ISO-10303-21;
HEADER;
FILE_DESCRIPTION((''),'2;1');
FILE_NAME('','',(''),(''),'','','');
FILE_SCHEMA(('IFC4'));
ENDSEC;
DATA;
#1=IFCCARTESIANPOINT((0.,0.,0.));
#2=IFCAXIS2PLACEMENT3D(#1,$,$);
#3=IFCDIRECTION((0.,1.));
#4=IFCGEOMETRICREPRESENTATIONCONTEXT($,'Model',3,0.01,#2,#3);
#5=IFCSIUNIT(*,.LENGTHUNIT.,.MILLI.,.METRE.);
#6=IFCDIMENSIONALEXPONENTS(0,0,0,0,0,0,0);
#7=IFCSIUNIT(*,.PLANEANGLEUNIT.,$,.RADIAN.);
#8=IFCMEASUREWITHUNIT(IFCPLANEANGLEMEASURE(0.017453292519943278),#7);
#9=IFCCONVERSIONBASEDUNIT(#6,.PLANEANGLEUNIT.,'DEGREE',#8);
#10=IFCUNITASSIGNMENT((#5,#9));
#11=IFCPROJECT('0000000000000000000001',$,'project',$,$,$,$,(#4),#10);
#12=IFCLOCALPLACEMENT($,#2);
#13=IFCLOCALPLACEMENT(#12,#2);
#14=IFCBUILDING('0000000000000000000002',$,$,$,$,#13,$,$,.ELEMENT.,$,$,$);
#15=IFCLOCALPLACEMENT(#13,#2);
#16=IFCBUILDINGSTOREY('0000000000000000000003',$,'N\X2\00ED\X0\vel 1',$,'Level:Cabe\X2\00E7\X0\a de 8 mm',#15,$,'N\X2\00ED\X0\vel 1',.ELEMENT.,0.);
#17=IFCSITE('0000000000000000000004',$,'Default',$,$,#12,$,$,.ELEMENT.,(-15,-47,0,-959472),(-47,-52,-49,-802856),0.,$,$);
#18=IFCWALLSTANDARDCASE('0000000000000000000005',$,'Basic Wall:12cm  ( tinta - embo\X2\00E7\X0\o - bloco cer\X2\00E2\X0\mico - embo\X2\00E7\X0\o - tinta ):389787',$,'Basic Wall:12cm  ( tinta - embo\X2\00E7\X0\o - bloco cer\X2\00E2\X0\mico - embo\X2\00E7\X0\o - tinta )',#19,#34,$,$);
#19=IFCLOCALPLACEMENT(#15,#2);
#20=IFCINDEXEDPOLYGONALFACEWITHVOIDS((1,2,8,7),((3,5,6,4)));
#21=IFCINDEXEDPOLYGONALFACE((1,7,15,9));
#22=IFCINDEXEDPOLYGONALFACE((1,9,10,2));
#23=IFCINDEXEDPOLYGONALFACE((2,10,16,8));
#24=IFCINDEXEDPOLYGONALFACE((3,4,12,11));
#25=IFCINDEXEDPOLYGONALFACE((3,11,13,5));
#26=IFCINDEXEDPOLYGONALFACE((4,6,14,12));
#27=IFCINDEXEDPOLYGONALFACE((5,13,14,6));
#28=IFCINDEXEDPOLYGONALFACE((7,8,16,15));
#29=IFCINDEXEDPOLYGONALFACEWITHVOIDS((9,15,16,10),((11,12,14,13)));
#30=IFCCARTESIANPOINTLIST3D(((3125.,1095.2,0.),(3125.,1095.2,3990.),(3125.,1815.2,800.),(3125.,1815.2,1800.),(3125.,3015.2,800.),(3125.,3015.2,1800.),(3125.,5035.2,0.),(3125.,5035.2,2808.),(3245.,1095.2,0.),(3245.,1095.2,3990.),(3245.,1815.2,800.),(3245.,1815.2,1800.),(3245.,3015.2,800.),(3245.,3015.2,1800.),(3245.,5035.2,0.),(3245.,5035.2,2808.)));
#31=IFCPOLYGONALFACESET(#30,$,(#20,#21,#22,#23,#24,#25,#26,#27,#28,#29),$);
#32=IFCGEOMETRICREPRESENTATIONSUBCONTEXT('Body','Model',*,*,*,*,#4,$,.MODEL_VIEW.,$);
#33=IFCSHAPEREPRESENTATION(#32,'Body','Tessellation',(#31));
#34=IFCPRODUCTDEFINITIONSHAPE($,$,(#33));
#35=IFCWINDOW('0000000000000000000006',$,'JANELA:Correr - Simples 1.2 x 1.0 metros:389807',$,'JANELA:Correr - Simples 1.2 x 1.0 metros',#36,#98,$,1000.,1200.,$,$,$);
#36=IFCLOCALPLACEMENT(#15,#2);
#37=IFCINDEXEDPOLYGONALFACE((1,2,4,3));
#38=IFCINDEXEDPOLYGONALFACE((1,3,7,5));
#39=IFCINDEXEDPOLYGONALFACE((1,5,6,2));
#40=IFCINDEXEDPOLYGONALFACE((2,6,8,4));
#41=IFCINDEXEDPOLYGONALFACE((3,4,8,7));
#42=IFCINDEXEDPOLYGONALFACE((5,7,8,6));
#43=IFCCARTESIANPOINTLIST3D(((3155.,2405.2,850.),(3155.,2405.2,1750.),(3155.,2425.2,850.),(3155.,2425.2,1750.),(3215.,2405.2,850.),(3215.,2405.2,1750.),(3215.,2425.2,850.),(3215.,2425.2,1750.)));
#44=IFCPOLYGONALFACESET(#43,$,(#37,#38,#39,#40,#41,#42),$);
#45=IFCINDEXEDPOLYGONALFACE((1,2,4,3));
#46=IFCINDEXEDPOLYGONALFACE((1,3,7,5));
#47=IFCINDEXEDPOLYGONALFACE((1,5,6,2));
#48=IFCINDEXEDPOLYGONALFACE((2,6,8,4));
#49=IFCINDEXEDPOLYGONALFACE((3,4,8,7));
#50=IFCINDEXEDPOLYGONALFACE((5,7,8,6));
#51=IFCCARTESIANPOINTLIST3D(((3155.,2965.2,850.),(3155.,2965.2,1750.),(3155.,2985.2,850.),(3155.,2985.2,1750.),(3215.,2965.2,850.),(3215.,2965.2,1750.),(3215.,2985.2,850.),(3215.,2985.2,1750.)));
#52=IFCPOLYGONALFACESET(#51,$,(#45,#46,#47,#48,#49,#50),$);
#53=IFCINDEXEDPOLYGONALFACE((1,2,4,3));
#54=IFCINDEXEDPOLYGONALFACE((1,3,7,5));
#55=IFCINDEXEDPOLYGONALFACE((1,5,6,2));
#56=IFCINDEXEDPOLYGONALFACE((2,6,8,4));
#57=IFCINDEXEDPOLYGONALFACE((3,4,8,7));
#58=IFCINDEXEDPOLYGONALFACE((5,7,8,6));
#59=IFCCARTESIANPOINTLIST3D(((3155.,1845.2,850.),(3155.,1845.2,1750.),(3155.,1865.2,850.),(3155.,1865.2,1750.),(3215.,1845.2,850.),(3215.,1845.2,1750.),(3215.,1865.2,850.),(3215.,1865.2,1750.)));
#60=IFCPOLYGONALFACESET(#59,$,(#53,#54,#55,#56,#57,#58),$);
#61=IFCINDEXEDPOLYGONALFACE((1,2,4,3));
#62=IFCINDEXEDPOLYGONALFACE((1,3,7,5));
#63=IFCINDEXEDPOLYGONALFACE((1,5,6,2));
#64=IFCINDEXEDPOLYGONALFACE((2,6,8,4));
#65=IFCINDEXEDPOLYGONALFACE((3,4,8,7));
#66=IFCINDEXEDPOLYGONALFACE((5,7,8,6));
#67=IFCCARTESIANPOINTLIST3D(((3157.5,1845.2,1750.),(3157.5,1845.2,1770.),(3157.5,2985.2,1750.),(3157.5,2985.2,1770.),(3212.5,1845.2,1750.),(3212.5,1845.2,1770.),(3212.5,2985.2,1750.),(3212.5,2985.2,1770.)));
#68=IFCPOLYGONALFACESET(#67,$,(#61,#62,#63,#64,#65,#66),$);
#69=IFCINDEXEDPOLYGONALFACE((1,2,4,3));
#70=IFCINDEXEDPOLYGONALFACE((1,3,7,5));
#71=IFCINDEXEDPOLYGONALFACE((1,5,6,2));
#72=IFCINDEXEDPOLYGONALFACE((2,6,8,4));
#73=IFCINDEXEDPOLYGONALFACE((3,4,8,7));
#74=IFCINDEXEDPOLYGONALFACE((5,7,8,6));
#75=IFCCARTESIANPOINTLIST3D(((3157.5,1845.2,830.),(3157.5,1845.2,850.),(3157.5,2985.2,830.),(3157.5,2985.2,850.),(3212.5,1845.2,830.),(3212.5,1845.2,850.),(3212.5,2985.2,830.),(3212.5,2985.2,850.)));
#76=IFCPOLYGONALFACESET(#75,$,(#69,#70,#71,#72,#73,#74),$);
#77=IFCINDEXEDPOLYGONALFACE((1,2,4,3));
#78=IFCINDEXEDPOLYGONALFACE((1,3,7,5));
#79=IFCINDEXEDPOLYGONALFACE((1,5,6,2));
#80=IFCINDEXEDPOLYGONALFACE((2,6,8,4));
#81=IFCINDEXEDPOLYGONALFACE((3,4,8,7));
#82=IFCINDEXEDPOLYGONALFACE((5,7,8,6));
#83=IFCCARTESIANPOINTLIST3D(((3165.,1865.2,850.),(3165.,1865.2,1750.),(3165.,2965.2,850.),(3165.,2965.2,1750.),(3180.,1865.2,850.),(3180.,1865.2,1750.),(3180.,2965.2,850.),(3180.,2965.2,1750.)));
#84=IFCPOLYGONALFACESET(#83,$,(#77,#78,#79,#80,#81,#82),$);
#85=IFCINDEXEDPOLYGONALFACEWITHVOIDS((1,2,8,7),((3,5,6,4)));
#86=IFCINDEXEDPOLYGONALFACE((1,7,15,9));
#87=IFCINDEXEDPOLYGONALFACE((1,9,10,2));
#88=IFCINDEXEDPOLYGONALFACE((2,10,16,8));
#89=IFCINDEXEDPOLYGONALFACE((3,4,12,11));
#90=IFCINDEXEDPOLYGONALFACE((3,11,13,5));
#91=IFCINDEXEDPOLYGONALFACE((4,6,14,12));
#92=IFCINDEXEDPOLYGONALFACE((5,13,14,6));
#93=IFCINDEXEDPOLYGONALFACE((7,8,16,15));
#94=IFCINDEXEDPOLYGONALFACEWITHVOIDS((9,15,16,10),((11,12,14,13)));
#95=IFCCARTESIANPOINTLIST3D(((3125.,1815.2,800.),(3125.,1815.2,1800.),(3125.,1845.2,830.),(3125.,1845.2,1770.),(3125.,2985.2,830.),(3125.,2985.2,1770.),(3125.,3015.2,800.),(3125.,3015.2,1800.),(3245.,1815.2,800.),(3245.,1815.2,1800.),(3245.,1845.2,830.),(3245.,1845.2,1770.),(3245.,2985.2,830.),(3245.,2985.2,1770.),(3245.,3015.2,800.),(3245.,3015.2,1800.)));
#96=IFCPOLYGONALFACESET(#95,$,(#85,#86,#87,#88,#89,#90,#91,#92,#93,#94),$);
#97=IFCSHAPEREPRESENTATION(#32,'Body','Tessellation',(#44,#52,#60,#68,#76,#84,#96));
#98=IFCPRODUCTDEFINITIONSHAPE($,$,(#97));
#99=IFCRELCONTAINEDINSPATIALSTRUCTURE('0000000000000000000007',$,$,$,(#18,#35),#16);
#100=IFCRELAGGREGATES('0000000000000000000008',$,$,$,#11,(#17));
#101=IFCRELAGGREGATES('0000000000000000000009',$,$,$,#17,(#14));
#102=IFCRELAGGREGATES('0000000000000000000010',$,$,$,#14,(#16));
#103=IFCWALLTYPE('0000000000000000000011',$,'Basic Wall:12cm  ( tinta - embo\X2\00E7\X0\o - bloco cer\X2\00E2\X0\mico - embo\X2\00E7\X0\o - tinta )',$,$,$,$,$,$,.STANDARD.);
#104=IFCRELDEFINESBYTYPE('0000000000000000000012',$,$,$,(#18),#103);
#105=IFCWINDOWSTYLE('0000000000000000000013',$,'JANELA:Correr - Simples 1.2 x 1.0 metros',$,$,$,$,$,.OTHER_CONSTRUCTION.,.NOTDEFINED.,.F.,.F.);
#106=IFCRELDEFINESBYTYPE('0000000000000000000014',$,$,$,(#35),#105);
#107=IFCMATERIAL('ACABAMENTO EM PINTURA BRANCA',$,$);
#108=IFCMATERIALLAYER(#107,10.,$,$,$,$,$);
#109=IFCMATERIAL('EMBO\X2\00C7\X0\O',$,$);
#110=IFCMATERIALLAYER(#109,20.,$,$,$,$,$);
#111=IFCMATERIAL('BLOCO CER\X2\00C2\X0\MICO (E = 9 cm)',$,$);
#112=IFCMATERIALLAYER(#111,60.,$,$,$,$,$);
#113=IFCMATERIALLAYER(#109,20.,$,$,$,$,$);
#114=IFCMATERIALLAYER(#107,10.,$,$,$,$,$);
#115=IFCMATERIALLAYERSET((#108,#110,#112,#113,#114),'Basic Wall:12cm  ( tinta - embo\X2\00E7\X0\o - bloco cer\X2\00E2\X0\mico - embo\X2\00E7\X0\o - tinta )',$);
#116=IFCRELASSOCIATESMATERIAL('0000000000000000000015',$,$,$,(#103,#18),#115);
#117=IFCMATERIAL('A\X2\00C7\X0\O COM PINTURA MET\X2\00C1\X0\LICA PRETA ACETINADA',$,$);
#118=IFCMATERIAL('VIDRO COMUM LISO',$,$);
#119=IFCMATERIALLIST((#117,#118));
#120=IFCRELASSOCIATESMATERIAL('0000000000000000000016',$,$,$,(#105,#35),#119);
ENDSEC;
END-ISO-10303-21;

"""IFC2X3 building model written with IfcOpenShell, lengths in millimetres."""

from ifc_helpers import new_model, entity, si_unit, converted_unit, direction, frame, frame_2d, origin, origin_2d_with_axis, place, context, subcontext, project, spatial, polyline, rectangle, outline, extrude, clip, bounded_halfspace, source, transform, mapped, material, material_list, layer, layer_set, layer_usage, type_object, type_shapes, element, fill, save


model = new_model("IFC2X3")

# Units and contexts
model_context = context("Model", 3, precision=0.01, world=origin(), true_north=direction((0.0, 1.0)))
body_context = subcontext(model_context, "Body", "Model", "MODEL_VIEW")
ifc_project = project(units=[si_unit("LENGTHUNIT", "METRE", prefix="MILLI"), converted_unit("PLANEANGLEUNIT", "DEGREE", entity("IfcPlaneAngleMeasure", 0.017453292519943278), si_unit("PLANEANGLEUNIT", "RADIAN"), dimensions=[0, 0, 0, 0, 0, 0, 0])], contexts=[model_context])

# Site, building, storey
site_placement = place(None, origin())
site = spatial("IfcSite", under=ifc_project, at=site_placement, Name="Default", CompositionType="ELEMENT", RefLatitude=(-15, -47, 0, -959472), RefLongitude=(-47, -52, -49, -802856), RefElevation=0.0)
building_placement = place(site_placement, origin())
building = spatial("IfcBuilding", under=site, at=building_placement, CompositionType="ELEMENT")
storey_placement = place(building_placement, origin())
storey = spatial("IfcBuildingStorey", under=building, at=storey_placement, Name="Nível 1", ObjectType="Level:Cabeça de 8 mm", LongName="Nível 1", CompositionType="ELEMENT", Elevation=0.0)

# Shared definitions
ifc_material_1 = material(Name="ACABAMENTO EM PINTURA BRANCA")

# Shared definitions
ifc_layer_1 = layer(ifc_material_1, 10.0)
ifc_material_2 = material(Name="EMBOÇO")
ifc_layer_2 = layer(ifc_material_2, 20.0)
ifc_material_3 = material(Name="BLOCO CERÂMICO (E = 9 cm)")
ifc_layer_3 = layer(ifc_material_3, 60.0)
ifc_layer_4 = layer(ifc_material_2, 20.0)
ifc_layer_5 = layer(ifc_material_1, 10.0)
ifc_layer_set_1 = layer_set([ifc_layer_1, ifc_layer_2, ifc_layer_3, ifc_layer_4, ifc_layer_5], Name="Basic Wall:12cm  ( tinta - emboço - bloco cerâmico - emboço - tinta )")
wall_type = type_object("IfcWallType", Name="Basic Wall:12cm  ( tinta - emboço - bloco cerâmico - emboço - tinta )", PredefinedType="STANDARD", material=ifc_layer_set_1)

# Wall, opening, window
ifc_layer_usage_1 = layer_usage(ifc_layer_set_1, "AXIS2", "NEGATIVE", 60.0)
wall_1_placement = place(storey_placement, frame((3185.0, 5035.2, 0.0), z_axis=(0.0, 0.0, 1.0), x_axis=(0.0, -1.0, 0.0)))
wall_1 = element("IfcWallStandardCase", 1, at=wall_1_placement, inside=storey, type_object=wall_type, material=ifc_layer_usage_1, Name="Basic Wall:12cm  ( tinta - emboço - bloco cerâmico - emboço - tinta ):389787", ObjectType="Basic Wall:12cm  ( tinta - emboço - bloco cerâmico - emboço - tinta )", context=body_context, shape_type="Clipping", body=[
    clip(extrude(rectangle(XDim=3940.0, YDim=120.0, at=frame_2d((1970.0, 0.0), x_axis=(-1.0, 0.0))), origin(), (0.0, 0.0, 1.0), 3990.0), bounded_halfspace(frame((0.0, -60.0, 2808.0), z_axis=(-0.287348, 0.0, 0.957826), x_axis=(0.0, -1.0, 0.0)), False, frame((0.0, -60.0, 2808.0)), polyline([(0.0, 0.0), (3940.0, 0.0), (3940.0, 120.0), (3820.0, 120.0), (120.0, 120.0), (0.0, 120.0), (0.0, 0.0)]))),
])
opening_1_placement = place(wall_1_placement, frame((2020.0, -60.0, 800.0)))
opening_1 = element("IfcOpeningElement", 2, at=opening_1_placement, cuts=wall_1, ObjectType="Opening", context=body_context, shape_type="SweptSolid", body=[
    extrude(rectangle(XDim=1000.0, YDim=1200.0, at=frame_2d((500.0, 600.0), x_axis=(1.0, 0.0))), frame((0.0, 0.0, 0.0), z_axis=(0.0, 1.0, 0.0), x_axis=(0.0, 0.0, 1.0)), (0.0, 0.0, 1.0), 120.0),
])
ifc_material_4 = material(Name="AÇO COM PINTURA METÁLICA PRETA ACETINADA")
ifc_material_5 = material(Name="VIDRO COMUM LISO")
ifc_material_list_1 = material_list([ifc_material_4, ifc_material_5])
window_style_1 = type_object("IfcWindowStyle", Name="JANELA:Correr - Simples 1.2 x 1.0 metros", ConstructionType="OTHER_CONSTRUCTION", OperationType="NOTDEFINED", ParameterTakesPrecedence=False, Sizeable=False, material=ifc_material_list_1)
shared_shape_1 = source(origin(), body_context, "Body", "SweptSolid", [
    extrude(rectangle(XDim=20.0, YDim=60.0, at=origin_2d_with_axis()), frame((600.0, 60.0, 50.0), z_axis=(0.0, 0.0, 1.0), x_axis=(-1.0, 0.0, 0.0)), (0.0, 0.0, 1.0), 900.0),
    extrude(rectangle(XDim=20.0, YDim=60.0, at=frame_2d((0.0, 0.0), x_axis=(1.0, 0.0))), frame((40.0, 60.0, 50.0), z_axis=(0.0, 0.0, 1.0), x_axis=(-1.0, 0.0, 0.0)), (0.0, 0.0, 1.0), 900.0),
    extrude(rectangle(XDim=20.0, YDim=60.0, at=frame_2d((0.0, 0.0), x_axis=(1.0, 0.0))), frame((1160.0, 60.0, 50.0), z_axis=(0.0, 0.0, 1.0), x_axis=(-1.0, 0.0, 0.0)), (0.0, 0.0, 1.0), 900.0),
    extrude(rectangle(XDim=1140.0, YDim=55.0, at=origin_2d_with_axis()), frame((600.0, 60.0, 950.0), z_axis=(0.0, 0.0, 1.0), x_axis=(-1.0, 0.0, 0.0)), (0.0, 0.0, 1.0), 20.0),
    extrude(rectangle(XDim=1140.0, YDim=55.0, at=origin_2d_with_axis()), frame((600.0, 60.0, 30.0), z_axis=(0.0, 0.0, 1.0), x_axis=(-1.0, 0.0, 0.0)), (0.0, 0.0, 1.0), 20.0),
    extrude(rectangle(XDim=15.0, YDim=1100.0, at=frame_2d((0.0, 0.0), x_axis=(1.0, 0.0))), frame((600.0, 47.5, 50.0), z_axis=(0.0, 0.0, 1.0), x_axis=(0.0, 1.0, 0.0)), (0.0, 0.0, 1.0), 900.0),
    extrude(outline(polyline([(-600.0, -500.0), (600.0, -500.0), (600.0, 500.0), (-600.0, 500.0), (-600.0, -500.0)]), holes=[polyline([(570.0, -470.0), (-570.0, -470.0), (-570.0, 470.0), (570.0, 470.0), (570.0, -470.0)])]), frame((600.0, 0.0, 500.0), z_axis=(0.0, 1.0, 0.0), x_axis=(1.0, 0.0, 0.0)), (0.0, 0.0, 1.0), 120.0),
])
type_shapes(window_style_1, [shared_shape_1])
window_1_placement = place(opening_1_placement, origin())
window_1 = element("IfcWindow", 3, at=window_1_placement, inside=storey, type_object=window_style_1, material=ifc_material_list_1, Name="JANELA:Correr - Simples 1.2 x 1.0 metros:389807", ObjectType="JANELA:Correr - Simples 1.2 x 1.0 metros", OverallHeight=1000.0, OverallWidth=1200.0, context=body_context, shape_type="MappedRepresentation", body=[
    mapped(shared_shape_1, transform((0.0, 0.0, 0.0), scale=1.0)),
])
fill(opening_1, window_1)

save(model, "model.ifc")
